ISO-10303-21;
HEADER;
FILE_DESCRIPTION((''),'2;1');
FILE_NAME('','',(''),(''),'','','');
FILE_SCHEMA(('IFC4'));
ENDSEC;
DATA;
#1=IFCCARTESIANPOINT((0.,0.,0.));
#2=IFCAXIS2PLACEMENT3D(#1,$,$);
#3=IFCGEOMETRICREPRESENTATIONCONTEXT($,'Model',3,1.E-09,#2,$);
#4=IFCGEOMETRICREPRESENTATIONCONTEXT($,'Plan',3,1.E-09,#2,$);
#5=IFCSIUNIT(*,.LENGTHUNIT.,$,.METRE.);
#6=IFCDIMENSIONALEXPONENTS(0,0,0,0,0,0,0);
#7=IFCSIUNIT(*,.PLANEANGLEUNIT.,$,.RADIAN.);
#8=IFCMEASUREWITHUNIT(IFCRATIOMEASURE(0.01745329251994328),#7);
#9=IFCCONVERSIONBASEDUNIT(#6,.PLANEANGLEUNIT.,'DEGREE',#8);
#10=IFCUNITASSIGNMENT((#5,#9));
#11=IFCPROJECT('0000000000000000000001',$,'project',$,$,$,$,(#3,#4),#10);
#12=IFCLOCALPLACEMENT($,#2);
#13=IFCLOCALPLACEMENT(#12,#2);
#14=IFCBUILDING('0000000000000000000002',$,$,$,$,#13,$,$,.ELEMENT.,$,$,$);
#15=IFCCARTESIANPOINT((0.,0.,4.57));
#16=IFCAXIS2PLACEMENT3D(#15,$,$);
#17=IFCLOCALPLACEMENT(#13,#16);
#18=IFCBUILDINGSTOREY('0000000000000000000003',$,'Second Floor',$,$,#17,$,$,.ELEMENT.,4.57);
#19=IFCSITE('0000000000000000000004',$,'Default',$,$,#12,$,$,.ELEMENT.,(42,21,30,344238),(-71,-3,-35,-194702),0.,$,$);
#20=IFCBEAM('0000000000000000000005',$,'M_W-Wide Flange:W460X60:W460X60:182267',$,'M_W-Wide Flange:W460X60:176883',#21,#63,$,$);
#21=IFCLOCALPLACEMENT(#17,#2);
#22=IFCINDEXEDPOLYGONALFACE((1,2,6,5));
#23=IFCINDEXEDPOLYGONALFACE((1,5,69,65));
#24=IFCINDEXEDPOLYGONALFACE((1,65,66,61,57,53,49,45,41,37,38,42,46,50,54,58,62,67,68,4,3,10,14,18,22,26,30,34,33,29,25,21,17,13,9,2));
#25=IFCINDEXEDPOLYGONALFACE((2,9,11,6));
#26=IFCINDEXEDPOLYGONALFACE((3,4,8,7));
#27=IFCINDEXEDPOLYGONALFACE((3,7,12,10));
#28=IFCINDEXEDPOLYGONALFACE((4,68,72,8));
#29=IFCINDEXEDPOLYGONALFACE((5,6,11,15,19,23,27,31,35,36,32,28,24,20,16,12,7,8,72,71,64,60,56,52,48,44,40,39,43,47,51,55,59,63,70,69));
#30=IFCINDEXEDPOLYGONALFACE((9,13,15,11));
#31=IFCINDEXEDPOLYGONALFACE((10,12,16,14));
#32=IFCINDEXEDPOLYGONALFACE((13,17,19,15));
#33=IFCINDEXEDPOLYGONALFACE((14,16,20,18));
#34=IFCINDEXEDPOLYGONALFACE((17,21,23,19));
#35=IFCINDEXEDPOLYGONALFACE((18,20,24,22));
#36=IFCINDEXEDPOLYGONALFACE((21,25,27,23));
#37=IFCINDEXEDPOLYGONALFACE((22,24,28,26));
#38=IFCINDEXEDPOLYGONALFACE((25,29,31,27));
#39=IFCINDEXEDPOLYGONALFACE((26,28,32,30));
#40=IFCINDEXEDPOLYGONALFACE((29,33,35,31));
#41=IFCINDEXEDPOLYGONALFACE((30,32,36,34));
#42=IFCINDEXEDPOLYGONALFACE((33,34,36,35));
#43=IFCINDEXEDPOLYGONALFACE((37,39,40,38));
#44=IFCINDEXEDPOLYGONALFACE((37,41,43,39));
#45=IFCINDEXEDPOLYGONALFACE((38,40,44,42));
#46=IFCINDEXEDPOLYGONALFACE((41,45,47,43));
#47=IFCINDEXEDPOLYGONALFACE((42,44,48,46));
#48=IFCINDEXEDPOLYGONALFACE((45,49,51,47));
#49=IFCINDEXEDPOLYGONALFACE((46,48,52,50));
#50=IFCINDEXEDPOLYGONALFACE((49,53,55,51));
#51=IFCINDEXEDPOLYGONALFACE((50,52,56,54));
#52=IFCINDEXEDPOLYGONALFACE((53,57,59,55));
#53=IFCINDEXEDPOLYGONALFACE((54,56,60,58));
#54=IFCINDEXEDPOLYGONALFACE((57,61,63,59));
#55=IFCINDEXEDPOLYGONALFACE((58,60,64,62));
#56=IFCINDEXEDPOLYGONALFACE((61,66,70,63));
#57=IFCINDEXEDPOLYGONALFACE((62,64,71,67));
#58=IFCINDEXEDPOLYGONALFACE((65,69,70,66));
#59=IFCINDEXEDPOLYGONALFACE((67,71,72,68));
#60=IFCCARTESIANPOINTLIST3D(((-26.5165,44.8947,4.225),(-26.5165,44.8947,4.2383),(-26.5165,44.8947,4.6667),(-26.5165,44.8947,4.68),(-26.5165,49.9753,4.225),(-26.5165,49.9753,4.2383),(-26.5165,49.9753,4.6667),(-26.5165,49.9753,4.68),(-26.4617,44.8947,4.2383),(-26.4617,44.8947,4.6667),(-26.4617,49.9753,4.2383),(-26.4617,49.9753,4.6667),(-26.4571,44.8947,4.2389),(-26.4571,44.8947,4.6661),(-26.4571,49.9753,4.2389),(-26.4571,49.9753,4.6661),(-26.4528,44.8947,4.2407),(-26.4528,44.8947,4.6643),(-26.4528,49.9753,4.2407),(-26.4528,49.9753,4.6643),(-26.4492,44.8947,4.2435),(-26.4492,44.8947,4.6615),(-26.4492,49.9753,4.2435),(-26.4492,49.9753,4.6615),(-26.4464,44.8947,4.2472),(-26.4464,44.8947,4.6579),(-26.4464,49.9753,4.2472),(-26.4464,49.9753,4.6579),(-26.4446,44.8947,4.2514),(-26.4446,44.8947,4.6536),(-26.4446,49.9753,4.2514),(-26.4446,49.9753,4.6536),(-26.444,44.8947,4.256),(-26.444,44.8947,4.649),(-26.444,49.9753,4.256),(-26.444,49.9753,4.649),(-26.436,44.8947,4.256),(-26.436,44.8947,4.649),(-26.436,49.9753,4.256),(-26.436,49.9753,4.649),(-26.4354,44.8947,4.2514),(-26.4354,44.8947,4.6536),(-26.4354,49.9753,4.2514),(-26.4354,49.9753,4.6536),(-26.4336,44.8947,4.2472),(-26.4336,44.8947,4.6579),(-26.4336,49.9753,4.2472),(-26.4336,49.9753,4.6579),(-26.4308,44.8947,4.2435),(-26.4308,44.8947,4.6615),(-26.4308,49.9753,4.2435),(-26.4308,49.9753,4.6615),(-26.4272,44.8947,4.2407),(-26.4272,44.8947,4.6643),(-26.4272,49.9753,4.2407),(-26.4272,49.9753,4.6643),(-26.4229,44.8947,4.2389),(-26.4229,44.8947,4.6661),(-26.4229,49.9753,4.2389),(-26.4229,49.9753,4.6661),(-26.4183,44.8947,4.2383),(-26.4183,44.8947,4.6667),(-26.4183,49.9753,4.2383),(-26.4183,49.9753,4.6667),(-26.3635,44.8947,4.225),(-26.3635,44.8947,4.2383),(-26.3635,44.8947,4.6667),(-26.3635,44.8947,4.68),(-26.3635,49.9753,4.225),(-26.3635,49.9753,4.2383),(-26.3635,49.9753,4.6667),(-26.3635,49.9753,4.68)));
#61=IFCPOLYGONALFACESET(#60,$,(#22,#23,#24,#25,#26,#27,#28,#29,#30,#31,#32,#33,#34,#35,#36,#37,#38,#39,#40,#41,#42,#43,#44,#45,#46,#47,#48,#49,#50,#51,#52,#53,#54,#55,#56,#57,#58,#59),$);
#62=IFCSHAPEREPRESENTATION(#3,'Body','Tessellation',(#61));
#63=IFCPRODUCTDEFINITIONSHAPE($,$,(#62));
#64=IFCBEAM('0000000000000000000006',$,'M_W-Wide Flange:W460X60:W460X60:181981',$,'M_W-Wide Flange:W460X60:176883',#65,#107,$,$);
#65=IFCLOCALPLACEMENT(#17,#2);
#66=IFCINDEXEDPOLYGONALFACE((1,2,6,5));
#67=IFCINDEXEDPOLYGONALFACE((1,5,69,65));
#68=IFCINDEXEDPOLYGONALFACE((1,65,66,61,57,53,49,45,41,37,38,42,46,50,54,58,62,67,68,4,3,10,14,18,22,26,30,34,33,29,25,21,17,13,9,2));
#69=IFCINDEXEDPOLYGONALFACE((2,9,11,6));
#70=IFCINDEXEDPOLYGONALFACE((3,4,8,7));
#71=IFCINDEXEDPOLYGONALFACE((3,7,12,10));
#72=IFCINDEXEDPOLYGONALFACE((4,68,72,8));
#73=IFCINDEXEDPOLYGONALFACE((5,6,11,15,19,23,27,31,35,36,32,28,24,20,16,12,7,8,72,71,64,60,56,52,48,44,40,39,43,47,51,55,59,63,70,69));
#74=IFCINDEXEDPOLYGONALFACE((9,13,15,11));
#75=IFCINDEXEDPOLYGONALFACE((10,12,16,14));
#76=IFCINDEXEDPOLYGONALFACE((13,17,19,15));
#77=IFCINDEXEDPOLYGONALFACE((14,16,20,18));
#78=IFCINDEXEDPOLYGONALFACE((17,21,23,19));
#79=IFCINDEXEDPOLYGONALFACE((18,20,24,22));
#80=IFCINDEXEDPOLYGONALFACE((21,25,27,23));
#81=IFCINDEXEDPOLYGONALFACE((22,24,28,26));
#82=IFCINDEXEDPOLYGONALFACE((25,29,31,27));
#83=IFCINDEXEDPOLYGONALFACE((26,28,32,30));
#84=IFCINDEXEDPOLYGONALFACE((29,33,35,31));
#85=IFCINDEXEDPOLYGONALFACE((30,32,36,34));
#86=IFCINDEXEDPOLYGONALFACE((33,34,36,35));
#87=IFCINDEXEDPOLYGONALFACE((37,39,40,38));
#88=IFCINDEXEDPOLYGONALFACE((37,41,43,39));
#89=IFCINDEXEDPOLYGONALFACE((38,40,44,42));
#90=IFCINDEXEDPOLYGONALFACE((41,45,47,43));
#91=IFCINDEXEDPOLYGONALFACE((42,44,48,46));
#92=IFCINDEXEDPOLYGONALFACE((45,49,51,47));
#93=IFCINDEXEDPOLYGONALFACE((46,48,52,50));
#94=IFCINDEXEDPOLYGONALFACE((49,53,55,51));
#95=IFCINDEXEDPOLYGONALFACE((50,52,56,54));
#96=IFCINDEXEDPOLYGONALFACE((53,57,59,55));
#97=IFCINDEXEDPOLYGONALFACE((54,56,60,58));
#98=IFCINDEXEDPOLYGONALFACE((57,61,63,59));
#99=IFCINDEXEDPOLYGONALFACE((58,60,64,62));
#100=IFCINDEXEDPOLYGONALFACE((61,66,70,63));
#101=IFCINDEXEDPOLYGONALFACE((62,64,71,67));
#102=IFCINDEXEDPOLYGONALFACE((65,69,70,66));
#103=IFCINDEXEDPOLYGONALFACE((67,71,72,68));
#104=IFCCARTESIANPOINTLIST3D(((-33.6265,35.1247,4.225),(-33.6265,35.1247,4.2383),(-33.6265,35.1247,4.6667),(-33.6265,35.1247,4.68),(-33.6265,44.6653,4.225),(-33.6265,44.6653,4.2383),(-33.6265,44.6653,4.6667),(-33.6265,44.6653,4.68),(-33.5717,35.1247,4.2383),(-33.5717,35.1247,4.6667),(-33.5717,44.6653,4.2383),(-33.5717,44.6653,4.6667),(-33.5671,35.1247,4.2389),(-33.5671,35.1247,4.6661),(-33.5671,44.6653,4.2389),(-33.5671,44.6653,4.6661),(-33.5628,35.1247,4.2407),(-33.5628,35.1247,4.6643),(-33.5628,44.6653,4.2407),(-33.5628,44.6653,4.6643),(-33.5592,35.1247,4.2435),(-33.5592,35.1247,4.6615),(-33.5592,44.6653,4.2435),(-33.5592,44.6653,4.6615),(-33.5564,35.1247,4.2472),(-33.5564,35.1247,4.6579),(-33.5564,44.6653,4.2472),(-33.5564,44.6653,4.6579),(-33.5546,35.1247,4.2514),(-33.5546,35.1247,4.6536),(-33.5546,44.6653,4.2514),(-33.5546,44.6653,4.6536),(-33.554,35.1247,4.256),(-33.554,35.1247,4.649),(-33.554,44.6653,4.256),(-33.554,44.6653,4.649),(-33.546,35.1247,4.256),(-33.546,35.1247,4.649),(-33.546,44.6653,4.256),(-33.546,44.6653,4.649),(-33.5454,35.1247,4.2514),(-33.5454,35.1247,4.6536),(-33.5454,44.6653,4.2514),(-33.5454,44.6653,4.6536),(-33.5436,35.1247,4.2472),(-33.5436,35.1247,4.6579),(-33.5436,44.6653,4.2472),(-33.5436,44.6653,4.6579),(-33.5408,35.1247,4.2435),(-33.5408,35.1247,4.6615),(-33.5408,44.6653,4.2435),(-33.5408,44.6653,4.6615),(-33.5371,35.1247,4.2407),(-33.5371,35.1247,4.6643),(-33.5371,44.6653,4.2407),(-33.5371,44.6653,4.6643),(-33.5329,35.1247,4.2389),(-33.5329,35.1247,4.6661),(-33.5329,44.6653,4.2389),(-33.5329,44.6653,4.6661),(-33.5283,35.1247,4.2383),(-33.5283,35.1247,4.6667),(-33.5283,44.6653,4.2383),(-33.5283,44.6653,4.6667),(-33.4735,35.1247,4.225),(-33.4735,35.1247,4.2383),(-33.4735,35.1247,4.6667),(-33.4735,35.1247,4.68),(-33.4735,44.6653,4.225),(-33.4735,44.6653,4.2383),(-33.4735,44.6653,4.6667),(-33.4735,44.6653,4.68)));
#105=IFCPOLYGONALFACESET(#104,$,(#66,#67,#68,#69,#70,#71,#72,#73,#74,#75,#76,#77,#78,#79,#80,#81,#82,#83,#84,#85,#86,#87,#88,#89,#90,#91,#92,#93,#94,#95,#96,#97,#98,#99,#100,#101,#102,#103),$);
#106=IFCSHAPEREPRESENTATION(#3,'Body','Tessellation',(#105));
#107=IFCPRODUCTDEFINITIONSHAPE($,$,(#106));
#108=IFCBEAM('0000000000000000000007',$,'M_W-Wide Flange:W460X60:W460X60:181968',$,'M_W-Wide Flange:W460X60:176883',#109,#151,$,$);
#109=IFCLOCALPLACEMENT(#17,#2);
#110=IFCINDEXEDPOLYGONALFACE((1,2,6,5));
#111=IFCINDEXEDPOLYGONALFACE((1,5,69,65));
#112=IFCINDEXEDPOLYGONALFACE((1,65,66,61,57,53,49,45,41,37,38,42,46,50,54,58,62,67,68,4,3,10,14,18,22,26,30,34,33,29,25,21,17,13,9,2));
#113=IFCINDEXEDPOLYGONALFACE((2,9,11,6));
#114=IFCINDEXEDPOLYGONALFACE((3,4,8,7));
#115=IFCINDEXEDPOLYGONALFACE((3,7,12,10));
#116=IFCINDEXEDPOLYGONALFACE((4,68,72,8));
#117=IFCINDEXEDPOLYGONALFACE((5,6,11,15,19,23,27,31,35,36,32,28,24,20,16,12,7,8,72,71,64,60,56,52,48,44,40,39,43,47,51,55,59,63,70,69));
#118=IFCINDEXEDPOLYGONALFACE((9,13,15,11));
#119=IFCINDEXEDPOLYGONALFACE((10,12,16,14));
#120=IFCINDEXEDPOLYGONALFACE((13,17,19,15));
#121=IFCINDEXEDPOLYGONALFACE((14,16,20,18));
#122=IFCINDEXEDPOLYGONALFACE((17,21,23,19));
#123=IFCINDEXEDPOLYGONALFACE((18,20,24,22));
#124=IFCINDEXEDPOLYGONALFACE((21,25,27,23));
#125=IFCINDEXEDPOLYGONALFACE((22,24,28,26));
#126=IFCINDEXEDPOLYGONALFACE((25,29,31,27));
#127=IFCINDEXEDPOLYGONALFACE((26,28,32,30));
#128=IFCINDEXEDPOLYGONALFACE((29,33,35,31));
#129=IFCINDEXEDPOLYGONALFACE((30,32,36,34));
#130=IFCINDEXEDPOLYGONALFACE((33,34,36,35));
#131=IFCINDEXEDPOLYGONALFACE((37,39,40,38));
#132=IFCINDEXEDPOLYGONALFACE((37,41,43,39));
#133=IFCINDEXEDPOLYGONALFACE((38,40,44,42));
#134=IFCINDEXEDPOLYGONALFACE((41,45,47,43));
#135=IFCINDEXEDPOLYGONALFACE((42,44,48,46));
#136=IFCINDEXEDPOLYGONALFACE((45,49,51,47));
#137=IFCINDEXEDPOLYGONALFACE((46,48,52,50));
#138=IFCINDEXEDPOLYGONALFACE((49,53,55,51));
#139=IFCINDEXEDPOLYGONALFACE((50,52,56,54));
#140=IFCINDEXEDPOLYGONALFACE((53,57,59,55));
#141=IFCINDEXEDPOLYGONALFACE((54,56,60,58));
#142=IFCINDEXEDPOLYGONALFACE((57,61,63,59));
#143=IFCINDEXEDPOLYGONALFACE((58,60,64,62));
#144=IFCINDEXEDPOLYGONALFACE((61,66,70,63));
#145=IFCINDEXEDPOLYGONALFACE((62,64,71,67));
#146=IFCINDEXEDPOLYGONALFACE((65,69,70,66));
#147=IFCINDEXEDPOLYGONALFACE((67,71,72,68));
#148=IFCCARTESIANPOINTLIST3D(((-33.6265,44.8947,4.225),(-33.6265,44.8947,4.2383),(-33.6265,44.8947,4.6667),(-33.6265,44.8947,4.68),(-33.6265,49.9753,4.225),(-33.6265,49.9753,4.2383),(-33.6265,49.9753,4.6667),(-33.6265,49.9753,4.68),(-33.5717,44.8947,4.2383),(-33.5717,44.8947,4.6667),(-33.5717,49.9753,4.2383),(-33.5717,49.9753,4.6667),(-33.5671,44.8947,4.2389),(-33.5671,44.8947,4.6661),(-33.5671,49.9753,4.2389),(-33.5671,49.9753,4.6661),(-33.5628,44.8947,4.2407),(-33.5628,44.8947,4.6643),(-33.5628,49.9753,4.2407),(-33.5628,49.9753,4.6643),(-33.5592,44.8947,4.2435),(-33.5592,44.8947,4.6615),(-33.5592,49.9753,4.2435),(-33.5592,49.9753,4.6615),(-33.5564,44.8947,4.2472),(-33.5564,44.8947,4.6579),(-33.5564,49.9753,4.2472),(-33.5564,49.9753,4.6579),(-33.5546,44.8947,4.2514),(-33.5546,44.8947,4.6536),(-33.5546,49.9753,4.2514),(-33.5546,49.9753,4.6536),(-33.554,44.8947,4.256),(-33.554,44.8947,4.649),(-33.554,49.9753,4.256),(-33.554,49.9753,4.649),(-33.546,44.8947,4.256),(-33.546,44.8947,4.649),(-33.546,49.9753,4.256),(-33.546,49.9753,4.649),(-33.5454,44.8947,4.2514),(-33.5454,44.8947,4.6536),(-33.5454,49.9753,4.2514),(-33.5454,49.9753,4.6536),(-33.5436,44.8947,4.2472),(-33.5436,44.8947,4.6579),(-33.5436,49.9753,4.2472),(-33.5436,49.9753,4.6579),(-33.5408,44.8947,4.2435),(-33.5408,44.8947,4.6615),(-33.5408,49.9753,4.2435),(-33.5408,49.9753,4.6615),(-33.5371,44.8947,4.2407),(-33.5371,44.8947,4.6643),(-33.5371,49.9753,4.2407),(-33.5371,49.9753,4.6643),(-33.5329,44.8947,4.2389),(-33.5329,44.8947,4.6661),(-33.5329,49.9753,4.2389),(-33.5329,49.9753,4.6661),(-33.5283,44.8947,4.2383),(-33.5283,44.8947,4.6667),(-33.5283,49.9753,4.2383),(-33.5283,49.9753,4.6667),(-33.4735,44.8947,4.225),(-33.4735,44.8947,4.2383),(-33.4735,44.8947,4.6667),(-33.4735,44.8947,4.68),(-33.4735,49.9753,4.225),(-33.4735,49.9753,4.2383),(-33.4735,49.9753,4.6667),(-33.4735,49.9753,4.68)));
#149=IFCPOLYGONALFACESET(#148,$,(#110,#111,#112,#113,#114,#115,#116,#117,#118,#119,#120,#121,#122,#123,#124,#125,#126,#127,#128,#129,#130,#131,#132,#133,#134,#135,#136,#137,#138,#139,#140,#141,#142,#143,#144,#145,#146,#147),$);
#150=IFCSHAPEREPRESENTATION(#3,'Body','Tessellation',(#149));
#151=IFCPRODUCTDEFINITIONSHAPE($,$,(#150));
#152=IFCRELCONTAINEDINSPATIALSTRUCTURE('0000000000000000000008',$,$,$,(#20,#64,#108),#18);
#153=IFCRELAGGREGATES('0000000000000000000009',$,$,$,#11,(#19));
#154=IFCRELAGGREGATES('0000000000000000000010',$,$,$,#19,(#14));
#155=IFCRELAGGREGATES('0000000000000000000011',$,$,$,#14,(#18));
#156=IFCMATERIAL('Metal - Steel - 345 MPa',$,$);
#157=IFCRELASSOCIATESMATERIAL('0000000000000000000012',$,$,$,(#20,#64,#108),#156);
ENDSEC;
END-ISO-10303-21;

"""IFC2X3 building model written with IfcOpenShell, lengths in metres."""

from ifc_helpers import new_model, entity, si_unit, converted_unit, frame, frame_2d, origin, place, context, project, spatial, polyline, circle_curve, parameter, trimmed, segment, composite_curve, outline, extrude, material, element, save


model = new_model("IFC2X3")

# Units and contexts
model_context = context("Model", 3, precision=1e-09, world=origin())
plan_context = context("Plan", 3, precision=1e-09, world=origin())
ifc_project = project(units=[si_unit("LENGTHUNIT", "METRE"), converted_unit("PLANEANGLEUNIT", "DEGREE", entity("IfcRatioMeasure", 0.01745329251994328), si_unit("PLANEANGLEUNIT", "RADIAN"), dimensions=[0, 0, 0, 0, 0, 0, 0])], contexts=[model_context, plan_context])

# Site, building, storey
site_placement = place(None, origin())
site = spatial("IfcSite", under=ifc_project, at=site_placement, Name="Default", CompositionType="ELEMENT", RefLatitude=(42, 21, 30, 344238), RefLongitude=(-71, -3, -35, -194702), RefElevation=0.0)
building_placement = place(site_placement, origin())
building = spatial("IfcBuilding", under=site, at=building_placement, CompositionType="ELEMENT")
storey_placement = place(building_placement, frame((0.0, 0.0, 4.57)))
storey = spatial("IfcBuildingStorey", under=building, at=storey_placement, Name="Second Floor", CompositionType="ELEMENT", Elevation=4.57)

# Shared definitions
ifc_material = material(Name="Metal - Steel - 345 MPa")

# Beams
beam_1_placement = place(storey_placement, frame((-26.44, 50.0864, 4.68), z_axis=(0.0, 0.0, 1.0), x_axis=(-1.0, 0.0, 0.0)))
element("IfcBeam", 1, at=beam_1_placement, inside=storey, material=ifc_material, Name="M_W-Wide Flange:W460X60:W460X60:182267", ObjectType="M_W-Wide Flange:W460X60:176883", context=model_context, shape_type="SweptSolid", body=[
    extrude(outline(composite_curve([segment(polyline([(0.2142, -0.0765), (0.2275, -0.0765)]), True, "CONTINUOUS"), segment(polyline([(0.2275, -0.0765), (0.2275, 0.0765)]), True, "CONTINUOUS"), segment(polyline([(0.2275, 0.0765), (0.2142, 0.0765)]), True, "CONTINUOUS"), segment(polyline([(0.2142, 0.0765), (0.2142, 0.0217)]), True, "CONTINUOUS"), segment(trimmed(circle_curve(frame_2d((0.1965, 0.0217), x_axis=(1.0, 0.0)), 0.0177), [parameter(270.0)], [parameter(360.0)], True, "PARAMETER"), False, "CONTINUOUS"), segment(polyline([(0.1965, 0.004), (-0.1965, 0.004)]), True, "CONTINUOUS"), segment(trimmed(circle_curve(frame_2d((-0.1965, 0.0217), x_axis=(0.0, -1.0)), 0.0177), [parameter(270.0)], [parameter(360.0)], True, "PARAMETER"), False, "CONTINUOUS"), segment(polyline([(-0.2142, 0.0217), (-0.2142, 0.0765)]), True, "CONTINUOUS"), segment(polyline([(-0.2142, 0.0765), (-0.2275, 0.0765)]), True, "CONTINUOUS"), segment(polyline([(-0.2275, 0.0765), (-0.2275, -0.0765)]), True, "CONTINUOUS"), segment(polyline([(-0.2275, -0.0765), (-0.2142, -0.0765)]), True, "CONTINUOUS"), segment(polyline([(-0.2142, -0.0765), (-0.2142, -0.0217)]), True, "CONTINUOUS"), segment(trimmed(circle_curve(frame_2d((-0.1965, -0.0217), x_axis=(-1.0, 0.0)), 0.0177), [parameter(270.0)], [parameter(360.0)], True, "PARAMETER"), False, "CONTINUOUS"), segment(polyline([(-0.1965, -0.004), (0.1965, -0.004)]), True, "CONTINUOUS"), segment(trimmed(circle_curve(frame_2d((0.1965, -0.0217), x_axis=(0.0, 1.0)), 0.0177), [parameter(270.0)], [parameter(0.0)], True, "PARAMETER"), False, "CONTINUOUS"), segment(polyline([(0.2142, -0.0217), (0.2142, -0.0765)]), True, "CONTINUOUS")], self_intersect=False)), frame((0.0, 5.1917, -0.2275), z_axis=(0.0, -1.0, 0.0), x_axis=(0.0, 0.0, -1.0)), (0.0, 0.0, 1.0), 5.0806),
])
beam_2_placement = place(storey_placement, frame((-33.55, 44.7781, 4.68), z_axis=(0.0, 0.0, 1.0), x_axis=(-1.0, 0.0, 0.0)))
element("IfcBeam", 2, at=beam_2_placement, inside=storey, material=ifc_material, Name="M_W-Wide Flange:W460X60:W460X60:181981", ObjectType="M_W-Wide Flange:W460X60:176883", context=model_context, shape_type="SweptSolid", body=[
    extrude(outline(composite_curve([segment(polyline([(0.2142, -0.0765), (0.2275, -0.0765)]), True, "CONTINUOUS"), segment(polyline([(0.2275, -0.0765), (0.2275, 0.0765)]), True, "CONTINUOUS"), segment(polyline([(0.2275, 0.0765), (0.2142, 0.0765)]), True, "CONTINUOUS"), segment(polyline([(0.2142, 0.0765), (0.2142, 0.0217)]), True, "CONTINUOUS"), segment(trimmed(circle_curve(frame_2d((0.1965, 0.0217), x_axis=(1.0, 0.0)), 0.0177), [parameter(270.0)], [parameter(360.0)], True, "PARAMETER"), False, "CONTINUOUS"), segment(polyline([(0.1965, 0.004), (-0.1965, 0.004)]), True, "CONTINUOUS"), segment(trimmed(circle_curve(frame_2d((-0.1965, 0.0217), x_axis=(0.0, -1.0)), 0.0177), [parameter(270.0)], [parameter(360.0)], True, "PARAMETER"), False, "CONTINUOUS"), segment(polyline([(-0.2142, 0.0217), (-0.2142, 0.0765)]), True, "CONTINUOUS"), segment(polyline([(-0.2142, 0.0765), (-0.2275, 0.0765)]), True, "CONTINUOUS"), segment(polyline([(-0.2275, 0.0765), (-0.2275, -0.0765)]), True, "CONTINUOUS"), segment(polyline([(-0.2275, -0.0765), (-0.2142, -0.0765)]), True, "CONTINUOUS"), segment(polyline([(-0.2142, -0.0765), (-0.2142, -0.0217)]), True, "CONTINUOUS"), segment(trimmed(circle_curve(frame_2d((-0.1965, -0.0217), x_axis=(-1.0, 0.0)), 0.0177), [parameter(270.0)], [parameter(360.0)], True, "PARAMETER"), False, "CONTINUOUS"), segment(polyline([(-0.1965, -0.004), (0.1965, -0.004)]), True, "CONTINUOUS"), segment(trimmed(circle_curve(frame_2d((0.1965, -0.0217), x_axis=(0.0, 1.0)), 0.0177), [parameter(270.0)], [parameter(0.0)], True, "PARAMETER"), False, "CONTINUOUS"), segment(polyline([(0.2142, -0.0217), (0.2142, -0.0765)]), True, "CONTINUOUS")], self_intersect=False)), frame((0.0, 9.6534, -0.2275), z_axis=(0.0, -1.0, 0.0), x_axis=(0.0, 0.0, -1.0)), (0.0, 0.0, 1.0), 9.5406),
])
beam_3_placement = place(storey_placement, frame((-33.55, 50.0864, 4.68), z_axis=(0.0, 0.0, 1.0), x_axis=(-1.0, 0.0, 0.0)))
element("IfcBeam", 3, at=beam_3_placement, inside=storey, material=ifc_material, Name="M_W-Wide Flange:W460X60:W460X60:181968", ObjectType="M_W-Wide Flange:W460X60:176883", context=model_context, shape_type="SweptSolid", body=[
    extrude(outline(composite_curve([segment(polyline([(0.2142, -0.0765), (0.2275, -0.0765)]), True, "CONTINUOUS"), segment(polyline([(0.2275, -0.0765), (0.2275, 0.0765)]), True, "CONTINUOUS"), segment(polyline([(0.2275, 0.0765), (0.2142, 0.0765)]), True, "CONTINUOUS"), segment(polyline([(0.2142, 0.0765), (0.2142, 0.0217)]), True, "CONTINUOUS"), segment(trimmed(circle_curve(frame_2d((0.1965, 0.0217), x_axis=(1.0, 0.0)), 0.0177), [parameter(270.0)], [parameter(360.0)], True, "PARAMETER"), False, "CONTINUOUS"), segment(polyline([(0.1965, 0.004), (-0.1965, 0.004)]), True, "CONTINUOUS"), segment(trimmed(circle_curve(frame_2d((-0.1965, 0.0217), x_axis=(0.0, -1.0)), 0.0177), [parameter(270.0)], [parameter(360.0)], True, "PARAMETER"), False, "CONTINUOUS"), segment(polyline([(-0.2142, 0.0217), (-0.2142, 0.0765)]), True, "CONTINUOUS"), segment(polyline([(-0.2142, 0.0765), (-0.2275, 0.0765)]), True, "CONTINUOUS"), segment(polyline([(-0.2275, 0.0765), (-0.2275, -0.0765)]), True, "CONTINUOUS"), segment(polyline([(-0.2275, -0.0765), (-0.2142, -0.0765)]), True, "CONTINUOUS"), segment(polyline([(-0.2142, -0.0765), (-0.2142, -0.0217)]), True, "CONTINUOUS"), segment(trimmed(circle_curve(frame_2d((-0.1965, -0.0217), x_axis=(-1.0, 0.0)), 0.0177), [parameter(270.0)], [parameter(360.0)], True, "PARAMETER"), False, "CONTINUOUS"), segment(polyline([(-0.1965, -0.004), (0.1965, -0.004)]), True, "CONTINUOUS"), segment(trimmed(circle_curve(frame_2d((0.1965, -0.0217), x_axis=(0.0, 1.0)), 0.0177), [parameter(270.0)], [parameter(0.0)], True, "PARAMETER"), False, "CONTINUOUS"), segment(polyline([(0.2142, -0.0217), (0.2142, -0.0765)]), True, "CONTINUOUS")], self_intersect=False)), frame((0.0, 5.1917, -0.2275), z_axis=(0.0, -1.0, 0.0), x_axis=(0.0, 0.0, -1.0)), (0.0, 0.0, 1.0), 5.0806),
])

save(model, "model.ifc")
